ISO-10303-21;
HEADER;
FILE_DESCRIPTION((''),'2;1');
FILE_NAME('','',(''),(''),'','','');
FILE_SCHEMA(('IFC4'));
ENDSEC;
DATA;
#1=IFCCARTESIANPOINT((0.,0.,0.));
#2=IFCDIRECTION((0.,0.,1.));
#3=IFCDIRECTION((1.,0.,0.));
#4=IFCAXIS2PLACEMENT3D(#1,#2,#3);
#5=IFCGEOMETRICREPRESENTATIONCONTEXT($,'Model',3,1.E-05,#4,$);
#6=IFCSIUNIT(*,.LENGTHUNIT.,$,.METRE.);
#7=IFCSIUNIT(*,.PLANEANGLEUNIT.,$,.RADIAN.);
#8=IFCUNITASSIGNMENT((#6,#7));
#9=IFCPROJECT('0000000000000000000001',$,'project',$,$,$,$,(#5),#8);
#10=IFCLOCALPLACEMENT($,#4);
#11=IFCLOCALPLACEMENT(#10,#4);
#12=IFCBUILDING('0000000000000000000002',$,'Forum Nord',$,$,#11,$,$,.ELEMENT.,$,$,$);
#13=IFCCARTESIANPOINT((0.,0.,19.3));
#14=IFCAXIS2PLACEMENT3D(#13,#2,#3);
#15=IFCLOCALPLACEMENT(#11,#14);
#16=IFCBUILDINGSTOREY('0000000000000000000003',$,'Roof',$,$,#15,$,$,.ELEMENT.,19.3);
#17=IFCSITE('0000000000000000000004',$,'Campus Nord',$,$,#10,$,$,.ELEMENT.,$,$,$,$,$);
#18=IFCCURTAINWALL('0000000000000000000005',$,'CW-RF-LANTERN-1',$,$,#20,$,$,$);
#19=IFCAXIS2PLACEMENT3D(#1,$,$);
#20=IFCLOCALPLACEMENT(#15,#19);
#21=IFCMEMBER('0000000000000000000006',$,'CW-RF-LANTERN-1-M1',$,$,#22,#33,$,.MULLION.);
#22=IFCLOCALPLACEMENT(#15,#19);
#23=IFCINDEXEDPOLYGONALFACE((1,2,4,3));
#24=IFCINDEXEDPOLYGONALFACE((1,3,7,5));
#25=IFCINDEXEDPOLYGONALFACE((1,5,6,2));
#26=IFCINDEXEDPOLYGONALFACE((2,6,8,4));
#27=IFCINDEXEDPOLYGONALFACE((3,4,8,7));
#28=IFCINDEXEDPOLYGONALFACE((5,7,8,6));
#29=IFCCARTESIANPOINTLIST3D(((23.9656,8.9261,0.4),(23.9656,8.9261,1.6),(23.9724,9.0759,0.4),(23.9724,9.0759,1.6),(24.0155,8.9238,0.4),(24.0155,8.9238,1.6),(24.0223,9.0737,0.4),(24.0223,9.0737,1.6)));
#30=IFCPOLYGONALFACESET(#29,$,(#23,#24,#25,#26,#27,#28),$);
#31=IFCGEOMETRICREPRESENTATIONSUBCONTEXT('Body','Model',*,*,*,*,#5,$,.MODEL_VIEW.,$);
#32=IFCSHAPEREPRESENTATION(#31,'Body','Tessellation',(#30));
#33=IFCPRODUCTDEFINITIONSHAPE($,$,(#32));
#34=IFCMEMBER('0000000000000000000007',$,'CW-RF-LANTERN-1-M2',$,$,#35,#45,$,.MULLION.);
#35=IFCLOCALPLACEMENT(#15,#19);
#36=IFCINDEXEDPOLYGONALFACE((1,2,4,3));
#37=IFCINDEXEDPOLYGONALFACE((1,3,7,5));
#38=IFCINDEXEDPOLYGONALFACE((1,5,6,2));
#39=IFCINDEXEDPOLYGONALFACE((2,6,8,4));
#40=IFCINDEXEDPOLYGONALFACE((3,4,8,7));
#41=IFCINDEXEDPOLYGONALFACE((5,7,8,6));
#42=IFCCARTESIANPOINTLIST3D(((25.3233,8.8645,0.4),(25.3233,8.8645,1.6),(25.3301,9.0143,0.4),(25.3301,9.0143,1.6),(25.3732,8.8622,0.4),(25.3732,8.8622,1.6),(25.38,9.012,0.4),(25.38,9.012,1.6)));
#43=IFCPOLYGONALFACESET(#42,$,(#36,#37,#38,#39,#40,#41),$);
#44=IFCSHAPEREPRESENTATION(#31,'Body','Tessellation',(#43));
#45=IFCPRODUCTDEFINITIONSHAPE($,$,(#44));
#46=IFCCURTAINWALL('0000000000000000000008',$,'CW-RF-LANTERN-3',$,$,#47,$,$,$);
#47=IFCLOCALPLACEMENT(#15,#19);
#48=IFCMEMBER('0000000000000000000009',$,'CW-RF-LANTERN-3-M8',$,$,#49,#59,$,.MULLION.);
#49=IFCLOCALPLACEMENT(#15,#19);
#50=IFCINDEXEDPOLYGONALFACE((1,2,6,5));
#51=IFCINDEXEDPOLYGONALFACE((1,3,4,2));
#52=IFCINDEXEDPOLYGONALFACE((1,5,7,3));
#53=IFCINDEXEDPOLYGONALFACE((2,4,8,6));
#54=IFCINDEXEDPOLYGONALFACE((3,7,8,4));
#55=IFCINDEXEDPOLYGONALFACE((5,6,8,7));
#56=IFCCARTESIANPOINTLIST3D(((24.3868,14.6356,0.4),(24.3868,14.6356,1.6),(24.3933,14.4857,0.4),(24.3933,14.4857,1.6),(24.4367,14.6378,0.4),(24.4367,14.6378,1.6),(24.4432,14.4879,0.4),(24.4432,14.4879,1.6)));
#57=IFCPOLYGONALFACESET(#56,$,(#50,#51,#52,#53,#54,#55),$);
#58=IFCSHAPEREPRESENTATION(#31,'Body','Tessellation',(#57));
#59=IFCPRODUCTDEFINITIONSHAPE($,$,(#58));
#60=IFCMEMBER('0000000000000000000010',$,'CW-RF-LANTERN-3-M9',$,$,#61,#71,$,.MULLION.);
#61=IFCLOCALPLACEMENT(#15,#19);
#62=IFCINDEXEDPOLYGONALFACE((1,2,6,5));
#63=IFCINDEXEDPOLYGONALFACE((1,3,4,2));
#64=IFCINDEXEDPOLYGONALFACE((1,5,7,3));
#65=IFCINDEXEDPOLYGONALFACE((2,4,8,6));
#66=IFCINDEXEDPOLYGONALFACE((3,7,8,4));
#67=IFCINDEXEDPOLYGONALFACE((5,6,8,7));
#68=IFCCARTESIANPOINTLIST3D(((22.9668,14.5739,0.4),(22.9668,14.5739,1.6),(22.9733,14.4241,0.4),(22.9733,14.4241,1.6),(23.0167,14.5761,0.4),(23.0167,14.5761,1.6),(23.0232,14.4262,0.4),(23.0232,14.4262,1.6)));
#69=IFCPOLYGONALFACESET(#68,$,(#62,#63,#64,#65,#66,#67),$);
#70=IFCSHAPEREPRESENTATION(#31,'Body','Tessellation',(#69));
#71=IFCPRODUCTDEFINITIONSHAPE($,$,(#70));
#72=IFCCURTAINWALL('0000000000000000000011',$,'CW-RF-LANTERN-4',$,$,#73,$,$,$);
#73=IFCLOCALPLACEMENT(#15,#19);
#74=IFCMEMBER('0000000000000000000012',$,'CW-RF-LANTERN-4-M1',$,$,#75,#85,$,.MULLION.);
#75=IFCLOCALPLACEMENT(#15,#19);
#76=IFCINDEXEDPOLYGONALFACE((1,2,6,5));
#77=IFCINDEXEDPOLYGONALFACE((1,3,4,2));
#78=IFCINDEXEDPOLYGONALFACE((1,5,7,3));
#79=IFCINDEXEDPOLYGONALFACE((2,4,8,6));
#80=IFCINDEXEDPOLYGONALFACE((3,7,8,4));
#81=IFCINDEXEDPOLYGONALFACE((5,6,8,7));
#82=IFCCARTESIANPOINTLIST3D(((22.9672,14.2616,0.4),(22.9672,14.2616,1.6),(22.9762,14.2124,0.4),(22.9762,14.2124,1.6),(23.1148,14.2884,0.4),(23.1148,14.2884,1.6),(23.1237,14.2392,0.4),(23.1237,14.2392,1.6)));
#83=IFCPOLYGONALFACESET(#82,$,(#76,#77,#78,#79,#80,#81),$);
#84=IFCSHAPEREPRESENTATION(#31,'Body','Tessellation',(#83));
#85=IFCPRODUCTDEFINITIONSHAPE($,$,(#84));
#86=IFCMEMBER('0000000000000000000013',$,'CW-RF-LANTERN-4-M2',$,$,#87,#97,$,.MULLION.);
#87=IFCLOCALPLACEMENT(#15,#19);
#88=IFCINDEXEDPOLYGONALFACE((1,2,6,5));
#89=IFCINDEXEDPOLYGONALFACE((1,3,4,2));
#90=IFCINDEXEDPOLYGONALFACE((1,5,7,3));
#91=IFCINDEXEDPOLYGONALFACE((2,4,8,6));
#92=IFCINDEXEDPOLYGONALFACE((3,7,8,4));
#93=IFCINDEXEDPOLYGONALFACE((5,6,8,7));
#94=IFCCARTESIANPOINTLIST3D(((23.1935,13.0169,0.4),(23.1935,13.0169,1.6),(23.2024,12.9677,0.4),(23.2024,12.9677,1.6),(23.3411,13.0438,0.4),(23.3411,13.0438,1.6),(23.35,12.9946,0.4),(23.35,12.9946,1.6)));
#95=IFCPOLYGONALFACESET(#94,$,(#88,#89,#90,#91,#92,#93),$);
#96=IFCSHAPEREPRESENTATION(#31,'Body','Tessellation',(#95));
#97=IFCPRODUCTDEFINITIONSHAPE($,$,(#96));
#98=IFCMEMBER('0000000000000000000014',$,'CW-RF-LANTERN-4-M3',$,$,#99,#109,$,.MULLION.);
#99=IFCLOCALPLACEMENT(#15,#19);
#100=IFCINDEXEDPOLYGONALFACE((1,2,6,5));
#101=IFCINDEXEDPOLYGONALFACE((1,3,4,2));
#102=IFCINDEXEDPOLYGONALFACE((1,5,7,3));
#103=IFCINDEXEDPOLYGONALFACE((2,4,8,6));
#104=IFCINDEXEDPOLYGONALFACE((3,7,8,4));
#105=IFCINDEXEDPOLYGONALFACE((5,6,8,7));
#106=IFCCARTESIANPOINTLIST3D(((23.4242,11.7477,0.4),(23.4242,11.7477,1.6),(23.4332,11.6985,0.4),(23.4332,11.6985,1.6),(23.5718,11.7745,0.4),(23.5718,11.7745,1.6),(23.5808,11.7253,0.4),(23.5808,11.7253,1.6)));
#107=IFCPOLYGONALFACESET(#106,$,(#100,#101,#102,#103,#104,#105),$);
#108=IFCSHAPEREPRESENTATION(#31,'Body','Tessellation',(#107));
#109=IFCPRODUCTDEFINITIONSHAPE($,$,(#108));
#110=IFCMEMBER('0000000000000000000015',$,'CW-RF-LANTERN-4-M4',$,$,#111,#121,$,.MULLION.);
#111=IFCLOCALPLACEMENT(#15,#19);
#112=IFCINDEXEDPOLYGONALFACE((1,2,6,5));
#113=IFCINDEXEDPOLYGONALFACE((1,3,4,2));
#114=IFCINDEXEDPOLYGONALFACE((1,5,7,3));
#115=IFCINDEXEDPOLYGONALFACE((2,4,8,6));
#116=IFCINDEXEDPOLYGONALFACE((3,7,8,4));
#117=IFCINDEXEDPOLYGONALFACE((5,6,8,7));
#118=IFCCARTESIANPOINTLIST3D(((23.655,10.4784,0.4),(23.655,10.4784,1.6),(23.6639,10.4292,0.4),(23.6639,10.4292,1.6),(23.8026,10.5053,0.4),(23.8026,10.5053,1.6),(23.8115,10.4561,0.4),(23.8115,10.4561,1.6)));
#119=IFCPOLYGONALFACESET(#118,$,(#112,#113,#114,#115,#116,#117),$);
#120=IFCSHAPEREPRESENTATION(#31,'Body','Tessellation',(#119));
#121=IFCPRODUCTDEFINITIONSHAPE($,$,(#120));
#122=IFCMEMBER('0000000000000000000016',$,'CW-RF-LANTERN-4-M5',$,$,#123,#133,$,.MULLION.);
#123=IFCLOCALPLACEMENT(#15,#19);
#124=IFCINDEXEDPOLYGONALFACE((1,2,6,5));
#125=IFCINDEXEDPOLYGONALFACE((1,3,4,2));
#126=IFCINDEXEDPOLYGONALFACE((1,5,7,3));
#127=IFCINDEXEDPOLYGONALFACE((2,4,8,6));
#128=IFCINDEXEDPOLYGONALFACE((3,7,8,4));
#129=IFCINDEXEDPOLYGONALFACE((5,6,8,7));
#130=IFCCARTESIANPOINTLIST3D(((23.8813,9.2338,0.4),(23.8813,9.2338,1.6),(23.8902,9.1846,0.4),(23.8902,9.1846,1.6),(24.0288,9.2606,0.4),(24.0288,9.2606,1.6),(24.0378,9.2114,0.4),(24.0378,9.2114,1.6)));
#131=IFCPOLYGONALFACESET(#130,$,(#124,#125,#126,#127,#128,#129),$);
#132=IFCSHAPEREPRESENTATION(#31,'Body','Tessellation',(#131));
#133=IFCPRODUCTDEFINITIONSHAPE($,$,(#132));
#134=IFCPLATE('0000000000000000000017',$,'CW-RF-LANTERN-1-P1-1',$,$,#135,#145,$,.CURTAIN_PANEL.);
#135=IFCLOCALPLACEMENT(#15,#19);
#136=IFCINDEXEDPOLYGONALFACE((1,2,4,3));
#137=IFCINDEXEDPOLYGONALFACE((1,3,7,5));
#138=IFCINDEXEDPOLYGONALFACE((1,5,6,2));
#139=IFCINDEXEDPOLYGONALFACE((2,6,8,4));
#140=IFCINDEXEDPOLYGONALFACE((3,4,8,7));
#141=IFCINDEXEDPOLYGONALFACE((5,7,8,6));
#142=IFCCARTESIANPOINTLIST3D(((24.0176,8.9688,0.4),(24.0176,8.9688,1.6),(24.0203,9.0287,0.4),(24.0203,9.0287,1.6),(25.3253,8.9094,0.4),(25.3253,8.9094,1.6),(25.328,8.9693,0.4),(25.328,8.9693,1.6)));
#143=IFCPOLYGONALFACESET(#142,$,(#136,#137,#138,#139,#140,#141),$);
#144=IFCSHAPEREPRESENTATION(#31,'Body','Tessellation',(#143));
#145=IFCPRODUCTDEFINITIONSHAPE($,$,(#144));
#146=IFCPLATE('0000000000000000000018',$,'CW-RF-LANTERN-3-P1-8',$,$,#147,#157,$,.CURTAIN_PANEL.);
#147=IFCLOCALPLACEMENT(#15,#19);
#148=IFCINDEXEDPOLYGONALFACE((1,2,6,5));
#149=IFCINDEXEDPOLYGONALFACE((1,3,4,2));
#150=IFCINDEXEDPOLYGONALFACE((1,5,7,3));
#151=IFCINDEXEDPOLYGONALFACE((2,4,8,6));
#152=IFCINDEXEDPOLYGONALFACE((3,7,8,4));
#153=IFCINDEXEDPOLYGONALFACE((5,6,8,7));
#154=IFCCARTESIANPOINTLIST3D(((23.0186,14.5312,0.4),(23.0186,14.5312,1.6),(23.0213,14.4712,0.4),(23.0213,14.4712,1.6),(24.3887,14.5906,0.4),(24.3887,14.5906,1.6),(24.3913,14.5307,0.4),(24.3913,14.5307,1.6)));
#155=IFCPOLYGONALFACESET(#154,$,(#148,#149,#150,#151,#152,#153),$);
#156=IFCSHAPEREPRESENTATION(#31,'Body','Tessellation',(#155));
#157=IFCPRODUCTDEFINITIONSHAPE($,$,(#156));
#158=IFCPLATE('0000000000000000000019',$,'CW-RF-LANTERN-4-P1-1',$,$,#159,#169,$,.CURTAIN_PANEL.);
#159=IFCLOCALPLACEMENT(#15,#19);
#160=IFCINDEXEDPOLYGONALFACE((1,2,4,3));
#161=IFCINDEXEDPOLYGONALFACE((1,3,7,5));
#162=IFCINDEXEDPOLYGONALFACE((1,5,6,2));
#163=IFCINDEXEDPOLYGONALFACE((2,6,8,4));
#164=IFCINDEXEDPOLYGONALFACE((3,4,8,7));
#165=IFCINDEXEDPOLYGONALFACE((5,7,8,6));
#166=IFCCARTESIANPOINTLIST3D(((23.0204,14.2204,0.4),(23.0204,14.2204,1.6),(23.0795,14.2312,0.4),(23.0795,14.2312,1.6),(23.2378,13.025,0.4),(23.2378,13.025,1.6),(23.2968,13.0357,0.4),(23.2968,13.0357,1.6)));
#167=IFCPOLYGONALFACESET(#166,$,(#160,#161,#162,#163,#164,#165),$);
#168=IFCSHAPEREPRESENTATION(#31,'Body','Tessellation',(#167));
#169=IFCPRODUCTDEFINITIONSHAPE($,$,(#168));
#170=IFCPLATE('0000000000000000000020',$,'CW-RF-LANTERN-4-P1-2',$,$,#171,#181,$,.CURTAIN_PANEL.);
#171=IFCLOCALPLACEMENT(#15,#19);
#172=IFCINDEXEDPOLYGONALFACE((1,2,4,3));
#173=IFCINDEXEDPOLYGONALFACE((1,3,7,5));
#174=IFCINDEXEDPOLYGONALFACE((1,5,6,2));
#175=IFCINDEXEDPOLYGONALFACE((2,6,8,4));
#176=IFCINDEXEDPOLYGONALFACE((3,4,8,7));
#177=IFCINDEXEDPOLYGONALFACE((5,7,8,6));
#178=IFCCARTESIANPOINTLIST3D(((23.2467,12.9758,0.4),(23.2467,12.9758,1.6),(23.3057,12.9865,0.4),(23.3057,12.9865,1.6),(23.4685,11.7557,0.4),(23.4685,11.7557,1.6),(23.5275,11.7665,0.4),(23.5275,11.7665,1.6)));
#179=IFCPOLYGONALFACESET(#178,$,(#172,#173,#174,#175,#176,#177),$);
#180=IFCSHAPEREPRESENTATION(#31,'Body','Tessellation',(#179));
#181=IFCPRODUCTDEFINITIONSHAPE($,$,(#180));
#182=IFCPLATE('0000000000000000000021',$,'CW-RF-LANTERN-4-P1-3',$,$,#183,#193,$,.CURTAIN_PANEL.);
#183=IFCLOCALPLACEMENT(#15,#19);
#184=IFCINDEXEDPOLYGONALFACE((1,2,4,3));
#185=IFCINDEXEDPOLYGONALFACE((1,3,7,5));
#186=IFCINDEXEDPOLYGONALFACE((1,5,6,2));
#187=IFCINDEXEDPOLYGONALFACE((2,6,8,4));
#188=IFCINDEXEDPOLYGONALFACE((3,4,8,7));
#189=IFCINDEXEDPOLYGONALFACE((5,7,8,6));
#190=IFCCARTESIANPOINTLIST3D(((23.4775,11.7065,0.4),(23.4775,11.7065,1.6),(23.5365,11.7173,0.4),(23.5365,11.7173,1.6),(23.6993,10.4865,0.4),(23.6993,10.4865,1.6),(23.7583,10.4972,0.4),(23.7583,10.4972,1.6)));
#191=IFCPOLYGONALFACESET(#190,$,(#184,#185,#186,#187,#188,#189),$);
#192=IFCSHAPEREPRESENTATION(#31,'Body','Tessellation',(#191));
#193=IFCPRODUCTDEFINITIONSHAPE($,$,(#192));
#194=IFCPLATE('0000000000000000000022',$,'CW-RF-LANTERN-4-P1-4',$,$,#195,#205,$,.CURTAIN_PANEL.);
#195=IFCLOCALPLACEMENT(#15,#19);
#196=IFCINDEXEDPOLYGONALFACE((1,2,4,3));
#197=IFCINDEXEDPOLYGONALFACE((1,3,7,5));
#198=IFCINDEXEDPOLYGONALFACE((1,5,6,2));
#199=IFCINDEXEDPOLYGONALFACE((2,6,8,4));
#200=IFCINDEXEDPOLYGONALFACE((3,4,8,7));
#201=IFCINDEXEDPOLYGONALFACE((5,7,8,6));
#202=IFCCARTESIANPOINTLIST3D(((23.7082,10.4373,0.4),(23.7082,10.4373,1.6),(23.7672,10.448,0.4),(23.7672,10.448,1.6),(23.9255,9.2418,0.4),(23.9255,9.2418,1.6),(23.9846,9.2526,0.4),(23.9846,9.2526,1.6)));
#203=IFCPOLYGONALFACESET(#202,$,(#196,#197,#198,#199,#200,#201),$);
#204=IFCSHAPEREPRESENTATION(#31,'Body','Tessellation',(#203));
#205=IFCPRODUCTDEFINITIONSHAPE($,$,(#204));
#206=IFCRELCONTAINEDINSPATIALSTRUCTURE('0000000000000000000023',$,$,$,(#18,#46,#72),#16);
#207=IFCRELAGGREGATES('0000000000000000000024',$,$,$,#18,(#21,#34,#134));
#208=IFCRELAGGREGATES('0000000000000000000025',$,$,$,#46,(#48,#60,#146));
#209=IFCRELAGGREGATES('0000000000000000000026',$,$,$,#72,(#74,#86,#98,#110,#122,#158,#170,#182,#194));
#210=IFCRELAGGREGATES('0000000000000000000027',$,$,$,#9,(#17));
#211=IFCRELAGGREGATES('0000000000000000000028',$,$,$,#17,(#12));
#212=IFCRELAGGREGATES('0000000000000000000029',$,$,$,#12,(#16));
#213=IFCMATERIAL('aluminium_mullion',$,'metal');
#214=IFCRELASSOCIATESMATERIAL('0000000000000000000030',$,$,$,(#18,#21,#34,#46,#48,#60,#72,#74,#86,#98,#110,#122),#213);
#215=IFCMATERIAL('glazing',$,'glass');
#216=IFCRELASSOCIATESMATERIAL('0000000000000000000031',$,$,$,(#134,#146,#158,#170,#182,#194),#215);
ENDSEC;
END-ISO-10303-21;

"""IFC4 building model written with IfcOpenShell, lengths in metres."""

from ifc_helpers import new_model, si_unit, frame, frame_2d, origin_with_axes, origin_2d_with_axis, place, context, subcontext, project, spatial, rectangle, extrude, material, element, aggregate, save


model = new_model("IFC4")

# Units and contexts
model_context = context("Model", 3, precision=1e-05, world=origin_with_axes())
body_context = subcontext(model_context, "Body", "Model", "MODEL_VIEW")
ifc_project = project(units=[si_unit("LENGTHUNIT", "METRE"), si_unit("PLANEANGLEUNIT", "RADIAN")], contexts=[model_context])

# Site, building, storey
site_placement = place(None, origin_with_axes())
site = spatial("IfcSite", under=ifc_project, at=site_placement, Name="Campus Nord", CompositionType="ELEMENT")
building_placement = place(site_placement, origin_with_axes())
building = spatial("IfcBuilding", under=site, at=building_placement, Name="Forum Nord", CompositionType="ELEMENT")
storey_placement = place(building_placement, frame((0.0, 0.0, 19.3), z_axis=(0.0, 0.0, 1.0), x_axis=(1.0, 0.0, 0.0)))
storey = spatial("IfcBuildingStorey", under=building, at=storey_placement, Name="Roof", CompositionType="ELEMENT", Elevation=19.3)

# Curtain walls, members
ifc_material_1 = material(Name="aluminium_mullion", Category="metal")
curtain_wall_1_placement = place(storey_placement, origin_with_axes())
curtain_wall_1 = element("IfcCurtainWall", 1, at=curtain_wall_1_placement, inside=storey, material=ifc_material_1, Name="CW-RF-LANTERN-1")
member_1_placement = place(storey_placement, frame((23.994, 8.9999, 0.4), z_axis=(0.0, 0.0, 1.0), x_axis=(0.99897, -0.04534, 0.0)))
member_1 = element("IfcMember", 2, at=member_1_placement, material=ifc_material_1, Name="CW-RF-LANTERN-1-M1", PredefinedType="MULLION", context=body_context, shape_type="SweptSolid", body=[
    extrude(rectangle(XDim=0.05, YDim=0.15, at=origin_2d_with_axis()), origin_with_axes(), (0.0, 0.0, 1.0), 1.2),
])
member_2_placement = place(storey_placement, frame((25.3516, 8.9383, 0.4), z_axis=(0.0, 0.0, 1.0), x_axis=(0.99897, -0.04534, 0.0)))
member_2 = element("IfcMember", 3, at=member_2_placement, material=ifc_material_1, Name="CW-RF-LANTERN-1-M2", PredefinedType="MULLION", context=body_context, shape_type="SweptSolid", body=[
    extrude(rectangle(XDim=0.05, YDim=0.15, at=origin_2d_with_axis()), origin_with_axes(), (0.0, 0.0, 1.0), 1.2),
])
curtain_wall_2_placement = place(storey_placement, origin_with_axes())
curtain_wall_2 = element("IfcCurtainWall", 4, at=curtain_wall_2_placement, inside=storey, material=ifc_material_1, Name="CW-RF-LANTERN-3")
member_3_placement = place(storey_placement, frame((24.415, 14.5617, 0.4), z_axis=(0.0, 0.0, 1.0), x_axis=(-0.99906, -0.04338, 0.0)))
member_3 = element("IfcMember", 5, at=member_3_placement, material=ifc_material_1, Name="CW-RF-LANTERN-3-M8", PredefinedType="MULLION", context=body_context, shape_type="SweptSolid", body=[
    extrude(rectangle(XDim=0.05, YDim=0.15, at=origin_2d_with_axis()), origin_with_axes(), (0.0, 0.0, 1.0), 1.2),
])
member_4_placement = place(storey_placement, frame((22.995, 14.5001, 0.4), z_axis=(0.0, 0.0, 1.0), x_axis=(-0.99906, -0.04338, 0.0)))
member_4 = element("IfcMember", 6, at=member_4_placement, material=ifc_material_1, Name="CW-RF-LANTERN-3-M9", PredefinedType="MULLION", context=body_context, shape_type="SweptSolid", body=[
    extrude(rectangle(XDim=0.05, YDim=0.15, at=origin_2d_with_axis()), origin_with_axes(), (0.0, 0.0, 1.0), 1.2),
])
curtain_wall_3_placement = place(storey_placement, origin_with_axes())
curtain_wall_3 = element("IfcCurtainWall", 7, at=curtain_wall_3_placement, inside=storey, material=ifc_material_1, Name="CW-RF-LANTERN-4")
member_5_placement = place(storey_placement, frame((23.0455, 14.2504, 0.4), z_axis=(0.0, 0.0, 1.0), x_axis=(0.17887, -0.98387, 0.0)))
member_5 = element("IfcMember", 8, at=member_5_placement, material=ifc_material_1, Name="CW-RF-LANTERN-4-M1", PredefinedType="MULLION", context=body_context, shape_type="SweptSolid", body=[
    extrude(rectangle(XDim=0.05, YDim=0.15, at=origin_2d_with_axis()), origin_with_axes(), (0.0, 0.0, 1.0), 1.2),
])
member_6_placement = place(storey_placement, frame((23.2718, 13.0058, 0.4), z_axis=(0.0, 0.0, 1.0), x_axis=(0.17887, -0.98387, 0.0)))
member_6 = element("IfcMember", 9, at=member_6_placement, material=ifc_material_1, Name="CW-RF-LANTERN-4-M2", PredefinedType="MULLION", context=body_context, shape_type="SweptSolid", body=[
    extrude(rectangle(XDim=0.05, YDim=0.15, at=origin_2d_with_axis()), origin_with_axes(), (0.0, 0.0, 1.0), 1.2),
])
member_7_placement = place(storey_placement, frame((23.5025, 11.7365, 0.4), z_axis=(0.0, 0.0, 1.0), x_axis=(0.17887, -0.98387, 0.0)))
member_7 = element("IfcMember", 10, at=member_7_placement, material=ifc_material_1, Name="CW-RF-LANTERN-4-M3", PredefinedType="MULLION", context=body_context, shape_type="SweptSolid", body=[
    extrude(rectangle(XDim=0.05, YDim=0.15, at=origin_2d_with_axis()), origin_with_axes(), (0.0, 0.0, 1.0), 1.2),
])
member_8_placement = place(storey_placement, frame((23.7333, 10.4672, 0.4), z_axis=(0.0, 0.0, 1.0), x_axis=(0.17887, -0.98387, 0.0)))
member_8 = element("IfcMember", 11, at=member_8_placement, material=ifc_material_1, Name="CW-RF-LANTERN-4-M4", PredefinedType="MULLION", context=body_context, shape_type="SweptSolid", body=[
    extrude(rectangle(XDim=0.05, YDim=0.15, at=origin_2d_with_axis()), origin_with_axes(), (0.0, 0.0, 1.0), 1.2),
])
member_9_placement = place(storey_placement, frame((23.9595, 9.2226, 0.4), z_axis=(0.0, 0.0, 1.0), x_axis=(0.17887, -0.98387, 0.0)))
member_9 = element("IfcMember", 12, at=member_9_placement, material=ifc_material_1, Name="CW-RF-LANTERN-4-M5", PredefinedType="MULLION", context=body_context, shape_type="SweptSolid", body=[
    extrude(rectangle(XDim=0.05, YDim=0.15, at=origin_2d_with_axis()), origin_with_axes(), (0.0, 0.0, 1.0), 1.2),
])

# Plates
ifc_material_2 = material(Name="glazing", Category="glass")
plate_1_placement = place(storey_placement, frame((24.019, 8.9987, 0.4), z_axis=(0.0, 0.0, 1.0), x_axis=(0.99897, -0.04534, 0.0)))
plate_1 = element("IfcPlate", 13, at=plate_1_placement, material=ifc_material_2, Name="CW-RF-LANTERN-1-P1-1", PredefinedType="CURTAIN_PANEL", context=body_context, shape_type="SweptSolid", body=[
    extrude(rectangle(XDim=1.3091, YDim=0.06, at=frame_2d((0.6545, 0.0), x_axis=(1.0, 0.0))), origin_with_axes(), (0.0, 0.0, 1.0), 1.2),
])
aggregate(curtain_wall_1, [member_1, member_2, plate_1])
plate_2_placement = place(storey_placement, frame((24.39, 14.5607, 0.4), z_axis=(0.0, 0.0, 1.0), x_axis=(-0.99906, -0.04338, 0.0)))
plate_2 = element("IfcPlate", 14, at=plate_2_placement, material=ifc_material_2, Name="CW-RF-LANTERN-3-P1-8", PredefinedType="CURTAIN_PANEL", context=body_context, shape_type="SweptSolid", body=[
    extrude(rectangle(XDim=1.3714, YDim=0.06, at=frame_2d((0.6857, 0.0), x_axis=(1.0, 0.0))), origin_with_axes(), (0.0, 0.0, 1.0), 1.2),
])
aggregate(curtain_wall_2, [member_3, member_4, plate_2])
plate_3_placement = place(storey_placement, frame((23.0499, 14.2258, 0.4), z_axis=(0.0, 0.0, 1.0), x_axis=(0.17887, -0.98387, 0.0)))
plate_3 = element("IfcPlate", 15, at=plate_3_placement, material=ifc_material_2, Name="CW-RF-LANTERN-4-P1-1", PredefinedType="CURTAIN_PANEL", context=body_context, shape_type="SweptSolid", body=[
    extrude(rectangle(XDim=1.215, YDim=0.06, at=frame_2d((0.6075, 0.0), x_axis=(1.0, 0.0))), origin_with_axes(), (0.0, 0.0, 1.0), 1.2),
])
plate_4_placement = place(storey_placement, frame((23.2762, 12.9811, 0.4), z_axis=(0.0, 0.0, 1.0), x_axis=(0.17887, -0.98387, 0.0)))
plate_4 = element("IfcPlate", 16, at=plate_4_placement, material=ifc_material_2, Name="CW-RF-LANTERN-4-P1-2", PredefinedType="CURTAIN_PANEL", context=body_context, shape_type="SweptSolid", body=[
    extrude(rectangle(XDim=1.2401, YDim=0.06, at=frame_2d((0.62, 0.0), x_axis=(1.0, 0.0))), origin_with_axes(), (0.0, 0.0, 1.0), 1.2),
])
plate_5_placement = place(storey_placement, frame((23.507, 11.7119, 0.4), z_axis=(0.0, 0.0, 1.0), x_axis=(0.17887, -0.98387, 0.0)))
plate_5 = element("IfcPlate", 17, at=plate_5_placement, material=ifc_material_2, Name="CW-RF-LANTERN-4-P1-3", PredefinedType="CURTAIN_PANEL", context=body_context, shape_type="SweptSolid", body=[
    extrude(rectangle(XDim=1.2401, YDim=0.06, at=frame_2d((0.62, 0.0), x_axis=(1.0, 0.0))), origin_with_axes(), (0.0, 0.0, 1.0), 1.2),
])
plate_6_placement = place(storey_placement, frame((23.7377, 10.4427, 0.4), z_axis=(0.0, 0.0, 1.0), x_axis=(0.17887, -0.98387, 0.0)))
plate_6 = element("IfcPlate", 18, at=plate_6_placement, material=ifc_material_2, Name="CW-RF-LANTERN-4-P1-4", PredefinedType="CURTAIN_PANEL", context=body_context, shape_type="SweptSolid", body=[
    extrude(rectangle(XDim=1.215, YDim=0.06, at=frame_2d((0.6075, 0.0), x_axis=(1.0, 0.0))), origin_with_axes(), (0.0, 0.0, 1.0), 1.2),
])
aggregate(curtain_wall_3, [member_5, member_6, member_7, member_8, member_9, plate_3, plate_4, plate_5, plate_6])

save(model, "model.ifc")
